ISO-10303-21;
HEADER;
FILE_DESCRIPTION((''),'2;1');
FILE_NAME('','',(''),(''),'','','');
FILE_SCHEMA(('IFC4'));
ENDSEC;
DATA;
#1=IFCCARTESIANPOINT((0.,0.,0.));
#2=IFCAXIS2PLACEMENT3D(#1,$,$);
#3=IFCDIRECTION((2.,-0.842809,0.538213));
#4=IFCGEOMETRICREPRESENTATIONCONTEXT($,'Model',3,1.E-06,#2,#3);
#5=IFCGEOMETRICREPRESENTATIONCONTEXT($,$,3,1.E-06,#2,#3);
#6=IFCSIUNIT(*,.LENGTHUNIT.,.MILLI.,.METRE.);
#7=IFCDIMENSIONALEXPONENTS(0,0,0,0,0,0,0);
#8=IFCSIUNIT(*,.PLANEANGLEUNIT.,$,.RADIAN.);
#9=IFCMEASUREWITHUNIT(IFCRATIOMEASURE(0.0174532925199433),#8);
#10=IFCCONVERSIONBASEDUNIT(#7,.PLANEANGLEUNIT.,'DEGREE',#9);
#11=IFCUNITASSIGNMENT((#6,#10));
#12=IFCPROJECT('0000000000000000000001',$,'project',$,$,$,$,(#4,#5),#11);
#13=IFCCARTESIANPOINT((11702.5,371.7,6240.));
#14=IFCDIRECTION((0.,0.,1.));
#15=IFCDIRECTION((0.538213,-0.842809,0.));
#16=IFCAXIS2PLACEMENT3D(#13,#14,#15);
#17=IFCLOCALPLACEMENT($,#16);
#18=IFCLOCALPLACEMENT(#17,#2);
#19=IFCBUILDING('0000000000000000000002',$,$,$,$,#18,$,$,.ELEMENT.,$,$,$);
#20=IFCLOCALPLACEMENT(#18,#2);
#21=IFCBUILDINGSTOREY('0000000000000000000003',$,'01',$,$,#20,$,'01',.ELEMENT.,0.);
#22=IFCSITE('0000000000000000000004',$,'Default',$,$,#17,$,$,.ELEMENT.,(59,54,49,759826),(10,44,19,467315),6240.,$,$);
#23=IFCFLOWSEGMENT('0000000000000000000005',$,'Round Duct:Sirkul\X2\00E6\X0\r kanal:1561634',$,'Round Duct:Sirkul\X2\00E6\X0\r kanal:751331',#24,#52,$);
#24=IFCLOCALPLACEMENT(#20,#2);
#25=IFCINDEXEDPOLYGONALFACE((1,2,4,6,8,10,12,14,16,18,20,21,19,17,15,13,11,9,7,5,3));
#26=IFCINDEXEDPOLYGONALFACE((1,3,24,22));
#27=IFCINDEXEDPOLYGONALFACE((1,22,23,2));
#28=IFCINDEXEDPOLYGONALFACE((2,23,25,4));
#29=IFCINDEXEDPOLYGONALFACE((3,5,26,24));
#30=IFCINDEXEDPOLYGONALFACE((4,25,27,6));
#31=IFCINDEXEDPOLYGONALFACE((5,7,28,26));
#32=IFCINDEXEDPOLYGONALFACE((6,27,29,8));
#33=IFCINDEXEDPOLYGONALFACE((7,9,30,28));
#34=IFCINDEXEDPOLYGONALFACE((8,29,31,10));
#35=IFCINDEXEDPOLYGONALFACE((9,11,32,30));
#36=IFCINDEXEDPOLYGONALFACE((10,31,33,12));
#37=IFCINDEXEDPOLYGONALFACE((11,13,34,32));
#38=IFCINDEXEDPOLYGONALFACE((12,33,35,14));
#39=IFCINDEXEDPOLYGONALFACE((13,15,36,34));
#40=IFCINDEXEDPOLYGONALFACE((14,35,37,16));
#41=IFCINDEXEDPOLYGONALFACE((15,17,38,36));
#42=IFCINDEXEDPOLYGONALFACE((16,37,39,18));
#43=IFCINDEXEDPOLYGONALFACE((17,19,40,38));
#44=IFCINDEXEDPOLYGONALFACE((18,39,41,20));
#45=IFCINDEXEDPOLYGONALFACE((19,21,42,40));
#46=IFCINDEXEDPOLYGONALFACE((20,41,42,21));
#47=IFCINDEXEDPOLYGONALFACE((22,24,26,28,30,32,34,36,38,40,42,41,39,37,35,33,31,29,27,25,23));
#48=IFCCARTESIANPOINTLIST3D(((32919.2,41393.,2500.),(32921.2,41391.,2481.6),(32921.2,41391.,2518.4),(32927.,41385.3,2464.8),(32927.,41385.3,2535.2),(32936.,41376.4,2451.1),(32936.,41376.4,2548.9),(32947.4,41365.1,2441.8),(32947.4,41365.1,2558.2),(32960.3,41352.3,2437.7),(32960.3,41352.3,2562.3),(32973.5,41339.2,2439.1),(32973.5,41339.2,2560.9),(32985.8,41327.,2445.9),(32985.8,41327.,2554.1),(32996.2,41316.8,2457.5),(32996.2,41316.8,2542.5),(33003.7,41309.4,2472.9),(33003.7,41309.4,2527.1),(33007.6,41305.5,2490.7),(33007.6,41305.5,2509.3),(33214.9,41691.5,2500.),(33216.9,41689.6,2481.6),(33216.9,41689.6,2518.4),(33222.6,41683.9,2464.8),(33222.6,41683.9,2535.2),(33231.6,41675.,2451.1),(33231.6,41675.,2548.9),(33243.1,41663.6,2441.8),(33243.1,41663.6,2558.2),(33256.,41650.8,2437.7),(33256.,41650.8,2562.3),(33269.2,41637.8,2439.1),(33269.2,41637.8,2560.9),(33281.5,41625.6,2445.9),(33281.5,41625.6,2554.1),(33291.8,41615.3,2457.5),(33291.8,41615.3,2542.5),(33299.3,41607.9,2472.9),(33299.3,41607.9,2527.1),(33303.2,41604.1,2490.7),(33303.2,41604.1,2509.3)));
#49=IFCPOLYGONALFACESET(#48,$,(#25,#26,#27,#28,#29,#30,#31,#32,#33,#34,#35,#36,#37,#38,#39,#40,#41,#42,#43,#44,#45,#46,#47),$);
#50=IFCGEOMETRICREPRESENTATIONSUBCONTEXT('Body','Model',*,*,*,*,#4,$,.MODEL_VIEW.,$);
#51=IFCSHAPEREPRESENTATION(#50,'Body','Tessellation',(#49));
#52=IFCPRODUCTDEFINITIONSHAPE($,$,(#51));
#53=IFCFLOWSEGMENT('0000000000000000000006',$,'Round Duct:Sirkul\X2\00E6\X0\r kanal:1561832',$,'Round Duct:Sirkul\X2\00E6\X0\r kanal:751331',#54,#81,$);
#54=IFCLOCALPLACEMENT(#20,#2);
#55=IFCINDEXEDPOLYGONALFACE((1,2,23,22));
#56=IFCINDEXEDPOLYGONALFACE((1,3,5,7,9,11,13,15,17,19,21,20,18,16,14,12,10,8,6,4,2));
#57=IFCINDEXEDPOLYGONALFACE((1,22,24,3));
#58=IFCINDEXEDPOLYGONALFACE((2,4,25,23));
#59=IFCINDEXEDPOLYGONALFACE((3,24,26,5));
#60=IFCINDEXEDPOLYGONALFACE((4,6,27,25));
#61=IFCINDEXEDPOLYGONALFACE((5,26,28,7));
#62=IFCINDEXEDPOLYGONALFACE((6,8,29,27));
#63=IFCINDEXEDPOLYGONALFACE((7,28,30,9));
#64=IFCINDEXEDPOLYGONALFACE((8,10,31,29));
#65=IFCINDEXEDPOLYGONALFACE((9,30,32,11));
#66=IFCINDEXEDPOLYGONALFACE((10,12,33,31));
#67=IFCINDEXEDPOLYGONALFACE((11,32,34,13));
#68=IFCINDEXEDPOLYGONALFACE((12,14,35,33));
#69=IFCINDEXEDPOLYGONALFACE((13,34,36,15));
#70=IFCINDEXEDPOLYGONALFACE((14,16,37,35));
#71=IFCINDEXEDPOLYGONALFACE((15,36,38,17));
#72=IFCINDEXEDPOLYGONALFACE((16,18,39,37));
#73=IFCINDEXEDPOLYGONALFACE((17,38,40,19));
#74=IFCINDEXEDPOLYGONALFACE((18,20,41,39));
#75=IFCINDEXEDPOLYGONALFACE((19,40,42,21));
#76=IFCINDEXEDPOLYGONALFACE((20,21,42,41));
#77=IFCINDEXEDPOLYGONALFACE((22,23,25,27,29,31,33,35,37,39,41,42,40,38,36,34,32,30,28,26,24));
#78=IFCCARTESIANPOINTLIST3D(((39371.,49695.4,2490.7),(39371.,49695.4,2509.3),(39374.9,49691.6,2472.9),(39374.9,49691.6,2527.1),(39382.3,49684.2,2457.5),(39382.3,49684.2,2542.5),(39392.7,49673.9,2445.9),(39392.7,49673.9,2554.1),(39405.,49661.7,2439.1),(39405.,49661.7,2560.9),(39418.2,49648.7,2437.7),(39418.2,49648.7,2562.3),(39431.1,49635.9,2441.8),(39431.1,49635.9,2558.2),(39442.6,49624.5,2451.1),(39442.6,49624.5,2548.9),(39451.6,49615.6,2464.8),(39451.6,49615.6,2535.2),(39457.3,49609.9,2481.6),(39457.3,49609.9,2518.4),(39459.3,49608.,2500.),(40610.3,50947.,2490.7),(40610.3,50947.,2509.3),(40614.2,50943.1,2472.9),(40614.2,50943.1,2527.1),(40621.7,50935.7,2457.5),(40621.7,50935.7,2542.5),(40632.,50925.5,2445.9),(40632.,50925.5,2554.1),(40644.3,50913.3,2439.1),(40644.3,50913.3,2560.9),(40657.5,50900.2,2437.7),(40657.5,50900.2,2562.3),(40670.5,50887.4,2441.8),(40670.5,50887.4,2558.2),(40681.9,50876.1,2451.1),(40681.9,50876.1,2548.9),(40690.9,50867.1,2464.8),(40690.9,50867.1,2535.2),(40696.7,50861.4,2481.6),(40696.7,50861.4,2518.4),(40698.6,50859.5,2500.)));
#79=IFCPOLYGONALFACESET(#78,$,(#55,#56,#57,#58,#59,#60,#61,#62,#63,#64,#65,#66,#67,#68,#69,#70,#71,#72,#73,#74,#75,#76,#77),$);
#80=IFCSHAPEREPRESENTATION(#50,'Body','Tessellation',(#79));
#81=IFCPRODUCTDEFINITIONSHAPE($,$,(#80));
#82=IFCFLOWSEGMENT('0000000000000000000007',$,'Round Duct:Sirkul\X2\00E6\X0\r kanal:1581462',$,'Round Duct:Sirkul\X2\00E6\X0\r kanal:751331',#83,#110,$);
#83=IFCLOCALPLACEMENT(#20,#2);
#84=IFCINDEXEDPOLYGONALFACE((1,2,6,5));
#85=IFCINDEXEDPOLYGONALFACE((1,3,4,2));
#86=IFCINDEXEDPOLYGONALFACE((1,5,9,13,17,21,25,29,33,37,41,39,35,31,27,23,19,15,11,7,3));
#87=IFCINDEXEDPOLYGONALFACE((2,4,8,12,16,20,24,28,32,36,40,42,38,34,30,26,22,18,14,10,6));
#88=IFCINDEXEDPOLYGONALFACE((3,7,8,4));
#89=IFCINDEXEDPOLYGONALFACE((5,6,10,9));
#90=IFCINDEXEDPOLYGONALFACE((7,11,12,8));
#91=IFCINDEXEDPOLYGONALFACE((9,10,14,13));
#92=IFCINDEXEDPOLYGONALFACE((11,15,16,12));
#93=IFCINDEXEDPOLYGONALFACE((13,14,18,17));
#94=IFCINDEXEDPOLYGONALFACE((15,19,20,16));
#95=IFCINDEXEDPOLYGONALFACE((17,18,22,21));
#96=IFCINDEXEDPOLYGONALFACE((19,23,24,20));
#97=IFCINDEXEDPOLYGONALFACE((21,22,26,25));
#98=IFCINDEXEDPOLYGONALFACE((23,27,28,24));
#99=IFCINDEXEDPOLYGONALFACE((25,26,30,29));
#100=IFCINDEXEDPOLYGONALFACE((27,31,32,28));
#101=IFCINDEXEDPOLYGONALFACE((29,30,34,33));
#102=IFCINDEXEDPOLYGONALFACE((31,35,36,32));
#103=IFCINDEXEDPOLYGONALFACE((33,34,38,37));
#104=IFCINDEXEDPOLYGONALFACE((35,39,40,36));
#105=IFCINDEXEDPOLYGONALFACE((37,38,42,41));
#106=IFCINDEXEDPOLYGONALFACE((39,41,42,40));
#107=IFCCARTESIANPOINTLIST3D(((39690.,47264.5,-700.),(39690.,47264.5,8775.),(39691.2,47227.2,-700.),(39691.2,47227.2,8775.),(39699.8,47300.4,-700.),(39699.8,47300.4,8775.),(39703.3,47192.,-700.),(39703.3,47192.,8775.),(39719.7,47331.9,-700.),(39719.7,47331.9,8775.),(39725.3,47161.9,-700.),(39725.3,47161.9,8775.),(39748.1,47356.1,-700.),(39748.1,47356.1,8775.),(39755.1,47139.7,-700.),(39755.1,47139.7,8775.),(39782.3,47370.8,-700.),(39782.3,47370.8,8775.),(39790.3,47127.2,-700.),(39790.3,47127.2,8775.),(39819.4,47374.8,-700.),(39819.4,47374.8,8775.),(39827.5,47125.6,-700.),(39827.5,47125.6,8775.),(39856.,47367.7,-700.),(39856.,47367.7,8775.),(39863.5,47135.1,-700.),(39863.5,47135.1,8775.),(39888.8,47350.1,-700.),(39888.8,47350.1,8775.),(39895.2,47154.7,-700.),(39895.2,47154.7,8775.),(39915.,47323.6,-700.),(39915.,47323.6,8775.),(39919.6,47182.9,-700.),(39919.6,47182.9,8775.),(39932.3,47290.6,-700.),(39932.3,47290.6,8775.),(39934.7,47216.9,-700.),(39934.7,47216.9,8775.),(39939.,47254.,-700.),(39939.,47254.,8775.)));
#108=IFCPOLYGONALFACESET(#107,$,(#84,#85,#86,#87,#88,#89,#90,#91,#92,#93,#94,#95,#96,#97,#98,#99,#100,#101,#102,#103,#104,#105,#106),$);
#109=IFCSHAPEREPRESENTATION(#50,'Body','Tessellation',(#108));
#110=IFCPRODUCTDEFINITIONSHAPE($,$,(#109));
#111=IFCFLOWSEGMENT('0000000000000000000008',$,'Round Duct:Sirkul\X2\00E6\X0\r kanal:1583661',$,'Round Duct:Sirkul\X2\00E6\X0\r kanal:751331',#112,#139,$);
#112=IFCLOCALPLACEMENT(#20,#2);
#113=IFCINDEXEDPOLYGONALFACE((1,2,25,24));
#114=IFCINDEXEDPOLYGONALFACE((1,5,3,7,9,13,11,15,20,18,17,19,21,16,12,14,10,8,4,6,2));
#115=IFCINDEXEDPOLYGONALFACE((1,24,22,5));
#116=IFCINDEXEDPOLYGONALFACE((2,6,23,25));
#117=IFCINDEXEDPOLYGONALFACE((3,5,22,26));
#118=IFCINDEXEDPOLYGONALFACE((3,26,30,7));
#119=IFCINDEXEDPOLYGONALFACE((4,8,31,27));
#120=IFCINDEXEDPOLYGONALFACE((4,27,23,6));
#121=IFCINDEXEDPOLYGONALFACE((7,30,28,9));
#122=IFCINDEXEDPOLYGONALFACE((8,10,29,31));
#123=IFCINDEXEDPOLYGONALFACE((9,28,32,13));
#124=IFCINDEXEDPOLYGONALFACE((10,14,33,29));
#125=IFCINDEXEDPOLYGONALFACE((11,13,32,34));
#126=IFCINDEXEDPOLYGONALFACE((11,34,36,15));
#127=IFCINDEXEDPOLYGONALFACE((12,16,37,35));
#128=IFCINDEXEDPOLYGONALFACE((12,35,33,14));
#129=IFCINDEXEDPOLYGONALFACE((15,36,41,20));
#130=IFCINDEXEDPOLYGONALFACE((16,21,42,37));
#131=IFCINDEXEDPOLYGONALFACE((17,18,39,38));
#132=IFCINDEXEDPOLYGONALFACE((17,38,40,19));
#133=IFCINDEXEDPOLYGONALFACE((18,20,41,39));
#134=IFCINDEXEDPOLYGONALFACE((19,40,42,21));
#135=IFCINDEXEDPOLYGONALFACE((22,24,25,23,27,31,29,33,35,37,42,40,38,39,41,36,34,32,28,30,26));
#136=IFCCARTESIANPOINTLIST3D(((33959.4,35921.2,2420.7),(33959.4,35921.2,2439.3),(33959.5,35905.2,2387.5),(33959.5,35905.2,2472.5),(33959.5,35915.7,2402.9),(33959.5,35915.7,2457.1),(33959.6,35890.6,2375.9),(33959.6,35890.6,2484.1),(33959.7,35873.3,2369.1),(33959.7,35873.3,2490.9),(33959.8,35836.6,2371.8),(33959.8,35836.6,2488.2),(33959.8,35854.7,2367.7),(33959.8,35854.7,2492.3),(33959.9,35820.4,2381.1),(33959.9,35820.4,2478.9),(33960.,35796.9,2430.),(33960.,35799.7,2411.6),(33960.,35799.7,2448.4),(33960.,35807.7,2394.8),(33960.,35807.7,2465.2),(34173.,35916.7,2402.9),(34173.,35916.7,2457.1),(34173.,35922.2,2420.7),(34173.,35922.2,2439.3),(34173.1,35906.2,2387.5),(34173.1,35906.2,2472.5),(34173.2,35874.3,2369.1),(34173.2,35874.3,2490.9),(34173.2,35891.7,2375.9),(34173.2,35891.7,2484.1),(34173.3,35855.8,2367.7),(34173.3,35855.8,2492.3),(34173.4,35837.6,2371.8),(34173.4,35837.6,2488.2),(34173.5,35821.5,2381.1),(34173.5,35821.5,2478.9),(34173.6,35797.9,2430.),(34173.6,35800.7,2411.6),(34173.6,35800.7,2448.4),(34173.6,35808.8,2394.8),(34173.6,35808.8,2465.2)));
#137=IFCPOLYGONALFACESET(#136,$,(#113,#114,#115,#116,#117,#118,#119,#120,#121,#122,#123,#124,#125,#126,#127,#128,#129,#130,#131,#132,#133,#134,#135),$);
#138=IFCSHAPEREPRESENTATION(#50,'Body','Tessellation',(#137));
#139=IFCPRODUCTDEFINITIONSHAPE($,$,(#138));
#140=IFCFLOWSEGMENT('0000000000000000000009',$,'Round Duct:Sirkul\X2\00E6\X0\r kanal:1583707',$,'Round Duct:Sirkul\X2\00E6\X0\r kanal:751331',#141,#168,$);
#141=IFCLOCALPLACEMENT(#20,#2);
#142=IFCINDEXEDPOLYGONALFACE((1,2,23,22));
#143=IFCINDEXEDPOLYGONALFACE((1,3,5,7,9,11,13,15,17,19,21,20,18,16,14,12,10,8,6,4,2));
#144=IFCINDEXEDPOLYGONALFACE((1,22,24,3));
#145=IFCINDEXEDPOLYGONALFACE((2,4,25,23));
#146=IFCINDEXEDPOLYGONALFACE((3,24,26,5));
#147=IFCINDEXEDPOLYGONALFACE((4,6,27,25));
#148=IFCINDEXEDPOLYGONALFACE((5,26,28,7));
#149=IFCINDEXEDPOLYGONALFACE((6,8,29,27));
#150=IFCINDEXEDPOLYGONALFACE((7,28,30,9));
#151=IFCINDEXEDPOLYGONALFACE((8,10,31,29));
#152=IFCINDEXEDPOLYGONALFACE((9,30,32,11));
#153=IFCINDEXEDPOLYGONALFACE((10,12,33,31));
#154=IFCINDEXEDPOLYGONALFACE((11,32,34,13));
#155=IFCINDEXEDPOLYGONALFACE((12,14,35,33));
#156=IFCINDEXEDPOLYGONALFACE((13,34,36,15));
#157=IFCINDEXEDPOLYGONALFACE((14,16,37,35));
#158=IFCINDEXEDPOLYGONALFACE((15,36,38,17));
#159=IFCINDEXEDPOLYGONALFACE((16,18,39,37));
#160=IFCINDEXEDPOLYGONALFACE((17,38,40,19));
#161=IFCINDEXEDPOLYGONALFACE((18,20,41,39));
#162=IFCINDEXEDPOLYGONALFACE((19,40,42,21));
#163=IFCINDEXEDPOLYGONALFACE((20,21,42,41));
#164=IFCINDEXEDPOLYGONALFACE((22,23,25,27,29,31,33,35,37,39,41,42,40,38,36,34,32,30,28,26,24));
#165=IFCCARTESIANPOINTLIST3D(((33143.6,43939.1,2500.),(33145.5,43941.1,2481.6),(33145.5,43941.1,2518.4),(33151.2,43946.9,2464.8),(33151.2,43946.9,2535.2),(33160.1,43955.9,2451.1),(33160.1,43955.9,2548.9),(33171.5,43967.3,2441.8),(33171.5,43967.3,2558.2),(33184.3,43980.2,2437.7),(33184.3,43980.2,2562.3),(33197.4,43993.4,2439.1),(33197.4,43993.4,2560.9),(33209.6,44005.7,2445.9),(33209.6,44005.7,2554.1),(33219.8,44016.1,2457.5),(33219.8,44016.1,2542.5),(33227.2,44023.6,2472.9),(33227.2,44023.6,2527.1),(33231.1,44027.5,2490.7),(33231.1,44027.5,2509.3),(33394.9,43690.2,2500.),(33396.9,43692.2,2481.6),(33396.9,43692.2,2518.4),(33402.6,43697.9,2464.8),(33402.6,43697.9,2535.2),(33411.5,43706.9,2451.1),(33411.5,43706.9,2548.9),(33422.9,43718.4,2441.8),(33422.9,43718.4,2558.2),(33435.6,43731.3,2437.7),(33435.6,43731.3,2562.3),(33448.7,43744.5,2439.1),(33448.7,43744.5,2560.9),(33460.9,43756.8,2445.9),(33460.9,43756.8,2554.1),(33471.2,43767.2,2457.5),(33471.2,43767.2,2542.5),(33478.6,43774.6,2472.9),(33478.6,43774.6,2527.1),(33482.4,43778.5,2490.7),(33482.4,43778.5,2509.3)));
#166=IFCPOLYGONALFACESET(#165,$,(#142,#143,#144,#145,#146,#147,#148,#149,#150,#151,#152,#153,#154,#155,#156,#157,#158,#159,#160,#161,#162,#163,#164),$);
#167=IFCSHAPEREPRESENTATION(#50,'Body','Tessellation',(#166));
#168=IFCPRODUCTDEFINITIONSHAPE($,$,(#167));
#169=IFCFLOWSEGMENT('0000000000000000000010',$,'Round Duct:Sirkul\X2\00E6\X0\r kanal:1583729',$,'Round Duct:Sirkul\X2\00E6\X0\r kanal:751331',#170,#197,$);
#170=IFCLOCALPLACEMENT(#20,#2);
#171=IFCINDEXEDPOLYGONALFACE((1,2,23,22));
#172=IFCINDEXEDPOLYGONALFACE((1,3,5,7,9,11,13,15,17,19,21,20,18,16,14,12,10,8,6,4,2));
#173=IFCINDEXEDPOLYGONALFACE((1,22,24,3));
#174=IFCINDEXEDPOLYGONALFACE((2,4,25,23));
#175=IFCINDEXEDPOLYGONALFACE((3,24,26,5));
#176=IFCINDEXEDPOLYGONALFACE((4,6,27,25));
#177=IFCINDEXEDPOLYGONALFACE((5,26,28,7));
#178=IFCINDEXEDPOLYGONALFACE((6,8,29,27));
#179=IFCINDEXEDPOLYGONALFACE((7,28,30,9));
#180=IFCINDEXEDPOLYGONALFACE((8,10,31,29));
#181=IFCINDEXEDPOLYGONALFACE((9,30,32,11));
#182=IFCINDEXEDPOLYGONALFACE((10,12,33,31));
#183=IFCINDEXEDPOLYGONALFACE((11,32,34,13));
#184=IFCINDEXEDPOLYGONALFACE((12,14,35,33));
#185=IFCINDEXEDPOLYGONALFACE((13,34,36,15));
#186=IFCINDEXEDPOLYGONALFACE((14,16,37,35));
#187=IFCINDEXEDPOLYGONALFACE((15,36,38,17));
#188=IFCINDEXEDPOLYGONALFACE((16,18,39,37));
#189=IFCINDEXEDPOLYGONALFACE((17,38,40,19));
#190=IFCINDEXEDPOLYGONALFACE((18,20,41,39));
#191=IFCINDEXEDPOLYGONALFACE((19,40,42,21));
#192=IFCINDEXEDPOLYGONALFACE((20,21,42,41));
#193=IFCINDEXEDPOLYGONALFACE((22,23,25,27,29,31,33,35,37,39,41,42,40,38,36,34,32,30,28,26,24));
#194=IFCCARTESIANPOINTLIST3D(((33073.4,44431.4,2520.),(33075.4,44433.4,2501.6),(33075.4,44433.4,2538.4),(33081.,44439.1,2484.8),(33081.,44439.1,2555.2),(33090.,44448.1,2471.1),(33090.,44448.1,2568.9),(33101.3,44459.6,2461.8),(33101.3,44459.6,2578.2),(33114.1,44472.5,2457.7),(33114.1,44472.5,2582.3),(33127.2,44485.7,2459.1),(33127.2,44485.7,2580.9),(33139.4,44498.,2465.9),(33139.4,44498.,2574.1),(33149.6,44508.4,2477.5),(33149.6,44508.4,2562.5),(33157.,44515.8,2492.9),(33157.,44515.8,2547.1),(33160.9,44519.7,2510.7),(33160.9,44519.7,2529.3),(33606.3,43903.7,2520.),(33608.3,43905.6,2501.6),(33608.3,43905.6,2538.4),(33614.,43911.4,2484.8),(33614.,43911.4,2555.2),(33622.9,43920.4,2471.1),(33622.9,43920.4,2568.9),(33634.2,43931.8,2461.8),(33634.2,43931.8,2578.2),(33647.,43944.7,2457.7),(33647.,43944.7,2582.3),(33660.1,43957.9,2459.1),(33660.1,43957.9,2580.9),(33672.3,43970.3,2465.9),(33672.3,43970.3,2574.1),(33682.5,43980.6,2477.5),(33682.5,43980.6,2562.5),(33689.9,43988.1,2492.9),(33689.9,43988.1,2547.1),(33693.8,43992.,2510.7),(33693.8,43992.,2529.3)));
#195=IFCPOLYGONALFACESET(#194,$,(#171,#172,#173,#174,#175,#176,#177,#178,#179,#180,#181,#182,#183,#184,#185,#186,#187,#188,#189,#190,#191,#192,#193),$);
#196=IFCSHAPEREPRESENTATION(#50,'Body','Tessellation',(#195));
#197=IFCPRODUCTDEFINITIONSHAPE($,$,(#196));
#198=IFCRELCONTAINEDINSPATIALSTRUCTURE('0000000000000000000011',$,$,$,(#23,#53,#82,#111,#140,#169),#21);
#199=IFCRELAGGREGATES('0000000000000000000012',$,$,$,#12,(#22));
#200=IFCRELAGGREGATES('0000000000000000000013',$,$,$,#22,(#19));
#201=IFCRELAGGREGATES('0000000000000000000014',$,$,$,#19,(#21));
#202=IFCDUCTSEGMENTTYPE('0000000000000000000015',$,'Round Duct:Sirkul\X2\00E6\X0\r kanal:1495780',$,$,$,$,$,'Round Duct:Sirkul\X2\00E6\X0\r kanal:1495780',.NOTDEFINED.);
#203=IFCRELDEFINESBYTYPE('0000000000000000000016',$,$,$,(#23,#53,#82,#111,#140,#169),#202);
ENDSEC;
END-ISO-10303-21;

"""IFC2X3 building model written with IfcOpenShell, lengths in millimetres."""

from ifc_helpers import new_model, entity, si_unit, converted_unit, direction, frame, frame_2d, origin, origin_2d_with_axis, place, context, subcontext, project, spatial, circle, extrude, type_object, element, save


model = new_model("IFC2X3")

# Units and contexts
model_context = context("Model", 3, precision=1e-06, world=origin(), true_north=direction((2.0, -0.842809, 0.538213)))
context_of_model = context(None, 3, precision=1e-06, world=origin(), true_north=direction((2.0, -0.842809, 0.538213)))
body_context = subcontext(model_context, "Body", "Model", "MODEL_VIEW")
ifc_project = project(units=[si_unit("LENGTHUNIT", "METRE", prefix="MILLI"), converted_unit("PLANEANGLEUNIT", "DEGREE", entity("IfcRatioMeasure", 0.0174532925199433), si_unit("PLANEANGLEUNIT", "RADIAN"), dimensions=[0, 0, 0, 0, 0, 0, 0])], contexts=[model_context, context_of_model])

# Site, building, storey
site_placement = place(None, frame((11702.5, 371.7, 6240.0), z_axis=(0.0, 0.0, 1.0), x_axis=(0.538213, -0.842809, 0.0)))
site = spatial("IfcSite", under=ifc_project, at=site_placement, Name="Default", CompositionType="ELEMENT", RefLatitude=(59, 54, 49, 759826), RefLongitude=(10, 44, 19, 467315), RefElevation=6240.0)
building_placement = place(site_placement, origin())
building = spatial("IfcBuilding", under=site, at=building_placement, CompositionType="ELEMENT")
storey_placement = place(building_placement, origin())
storey = spatial("IfcBuildingStorey", under=building, at=storey_placement, Name="01", LongName="01", CompositionType="ELEMENT", Elevation=0.0)

# Flow segments
duct_segment_type = type_object("IfcDuctSegmentType", Name="Round Duct:Sirkulær kanal:1495780", ElementType="Round Duct:Sirkulær kanal:1495780", PredefinedType="NOTDEFINED")
flow_segment_1_placement = place(storey_placement, origin())
element("IfcFlowSegment", 1, at=flow_segment_1_placement, inside=storey, type_object=duct_segment_type, Name="Round Duct:Sirkulær kanal:1561634", ObjectType="Round Duct:Sirkulær kanal:751331", context=body_context, shape_type="SweptSolid", body=[
    extrude(circle(Radius=62.5, at=origin_2d_with_axis()), frame((32963.6, 41349.0, 2500.0), z_axis=(0.703643, 0.710554, 0.0), x_axis=(-0.710554, 0.703643, 0.0)), (0.0, 0.0, 1.0), 420.2),
])
flow_segment_2_placement = place(storey_placement, origin())
element("IfcFlowSegment", 2, at=flow_segment_2_placement, inside=storey, type_object=duct_segment_type, Name="Round Duct:Sirkulær kanal:1561832", ObjectType="Round Duct:Sirkulær kanal:751331", context=body_context, shape_type="SweptSolid", body=[
    extrude(circle(Radius=62.5, at=origin_2d_with_axis()), frame((39414.9, 49651.9, 2500.0), z_axis=(0.703643, 0.710554, 0.0), x_axis=(0.710554, -0.703643, 0.0)), (0.0, 0.0, 1.0), 1761.3),
])
flow_segment_3_placement = place(storey_placement, origin())
element("IfcFlowSegment", 3, at=flow_segment_3_placement, inside=storey, type_object=duct_segment_type, Name="Round Duct:Sirkulær kanal:1581462", ObjectType="Round Duct:Sirkulær kanal:751331", context=body_context, shape_type="SweptSolid", body=[
    extrude(circle(Radius=125.0, at=frame_2d((0.0, 0.0), x_axis=(1.0, 0.0))), frame((39814.1, 47249.9, -700.0), z_axis=(0.0, 0.0, 1.0), x_axis=(-0.710554, -0.703643, 0.0)), (0.0, 0.0, 1.0), 9475.0),
])
flow_segment_4_placement = place(storey_placement, origin())
element("IfcFlowSegment", 4, at=flow_segment_4_placement, inside=storey, type_object=duct_segment_type, Name="Round Duct:Sirkulær kanal:1583661", ObjectType="Round Duct:Sirkulær kanal:751331", context=body_context, shape_type="SweptSolid", body=[
    extrude(circle(Radius=62.5, at=frame_2d((0.0, 0.0), x_axis=(1.0, 0.0))), frame((33959.7, 35859.4, 2430.0), z_axis=(0.999988, 0.004887, 0.0), x_axis=(0.004887, -0.999988, 0.0)), (0.0, 0.0, 1.0), 213.6),
])
flow_segment_5_placement = place(storey_placement, origin())
element("IfcFlowSegment", 5, at=flow_segment_5_placement, inside=storey, type_object=duct_segment_type, Name="Round Duct:Sirkulær kanal:1583707", ObjectType="Round Duct:Sirkulær kanal:751331", context=body_context, shape_type="SweptSolid", body=[
    extrude(circle(Radius=62.5, at=origin_2d_with_axis()), frame((33187.6, 43983.5, 2500.0), z_axis=(0.710554, -0.703643, 0.0), x_axis=(-0.703643, -0.710554, 0.0)), (0.0, 0.0, 1.0), 353.8),
])
flow_segment_6_placement = place(storey_placement, origin())
element("IfcFlowSegment", 6, at=flow_segment_6_placement, inside=storey, type_object=duct_segment_type, Name="Round Duct:Sirkulær kanal:1583729", ObjectType="Round Duct:Sirkulær kanal:751331", context=body_context, shape_type="SweptSolid", body=[
    extrude(circle(Radius=62.5, at=origin_2d_with_axis()), frame((33117.4, 44475.8, 2520.0), z_axis=(0.710554, -0.703643, 0.0), x_axis=(-0.703643, -0.710554, 0.0)), (0.0, 0.0, 1.0), 750.0),
])

save(model, "model.ifc")
